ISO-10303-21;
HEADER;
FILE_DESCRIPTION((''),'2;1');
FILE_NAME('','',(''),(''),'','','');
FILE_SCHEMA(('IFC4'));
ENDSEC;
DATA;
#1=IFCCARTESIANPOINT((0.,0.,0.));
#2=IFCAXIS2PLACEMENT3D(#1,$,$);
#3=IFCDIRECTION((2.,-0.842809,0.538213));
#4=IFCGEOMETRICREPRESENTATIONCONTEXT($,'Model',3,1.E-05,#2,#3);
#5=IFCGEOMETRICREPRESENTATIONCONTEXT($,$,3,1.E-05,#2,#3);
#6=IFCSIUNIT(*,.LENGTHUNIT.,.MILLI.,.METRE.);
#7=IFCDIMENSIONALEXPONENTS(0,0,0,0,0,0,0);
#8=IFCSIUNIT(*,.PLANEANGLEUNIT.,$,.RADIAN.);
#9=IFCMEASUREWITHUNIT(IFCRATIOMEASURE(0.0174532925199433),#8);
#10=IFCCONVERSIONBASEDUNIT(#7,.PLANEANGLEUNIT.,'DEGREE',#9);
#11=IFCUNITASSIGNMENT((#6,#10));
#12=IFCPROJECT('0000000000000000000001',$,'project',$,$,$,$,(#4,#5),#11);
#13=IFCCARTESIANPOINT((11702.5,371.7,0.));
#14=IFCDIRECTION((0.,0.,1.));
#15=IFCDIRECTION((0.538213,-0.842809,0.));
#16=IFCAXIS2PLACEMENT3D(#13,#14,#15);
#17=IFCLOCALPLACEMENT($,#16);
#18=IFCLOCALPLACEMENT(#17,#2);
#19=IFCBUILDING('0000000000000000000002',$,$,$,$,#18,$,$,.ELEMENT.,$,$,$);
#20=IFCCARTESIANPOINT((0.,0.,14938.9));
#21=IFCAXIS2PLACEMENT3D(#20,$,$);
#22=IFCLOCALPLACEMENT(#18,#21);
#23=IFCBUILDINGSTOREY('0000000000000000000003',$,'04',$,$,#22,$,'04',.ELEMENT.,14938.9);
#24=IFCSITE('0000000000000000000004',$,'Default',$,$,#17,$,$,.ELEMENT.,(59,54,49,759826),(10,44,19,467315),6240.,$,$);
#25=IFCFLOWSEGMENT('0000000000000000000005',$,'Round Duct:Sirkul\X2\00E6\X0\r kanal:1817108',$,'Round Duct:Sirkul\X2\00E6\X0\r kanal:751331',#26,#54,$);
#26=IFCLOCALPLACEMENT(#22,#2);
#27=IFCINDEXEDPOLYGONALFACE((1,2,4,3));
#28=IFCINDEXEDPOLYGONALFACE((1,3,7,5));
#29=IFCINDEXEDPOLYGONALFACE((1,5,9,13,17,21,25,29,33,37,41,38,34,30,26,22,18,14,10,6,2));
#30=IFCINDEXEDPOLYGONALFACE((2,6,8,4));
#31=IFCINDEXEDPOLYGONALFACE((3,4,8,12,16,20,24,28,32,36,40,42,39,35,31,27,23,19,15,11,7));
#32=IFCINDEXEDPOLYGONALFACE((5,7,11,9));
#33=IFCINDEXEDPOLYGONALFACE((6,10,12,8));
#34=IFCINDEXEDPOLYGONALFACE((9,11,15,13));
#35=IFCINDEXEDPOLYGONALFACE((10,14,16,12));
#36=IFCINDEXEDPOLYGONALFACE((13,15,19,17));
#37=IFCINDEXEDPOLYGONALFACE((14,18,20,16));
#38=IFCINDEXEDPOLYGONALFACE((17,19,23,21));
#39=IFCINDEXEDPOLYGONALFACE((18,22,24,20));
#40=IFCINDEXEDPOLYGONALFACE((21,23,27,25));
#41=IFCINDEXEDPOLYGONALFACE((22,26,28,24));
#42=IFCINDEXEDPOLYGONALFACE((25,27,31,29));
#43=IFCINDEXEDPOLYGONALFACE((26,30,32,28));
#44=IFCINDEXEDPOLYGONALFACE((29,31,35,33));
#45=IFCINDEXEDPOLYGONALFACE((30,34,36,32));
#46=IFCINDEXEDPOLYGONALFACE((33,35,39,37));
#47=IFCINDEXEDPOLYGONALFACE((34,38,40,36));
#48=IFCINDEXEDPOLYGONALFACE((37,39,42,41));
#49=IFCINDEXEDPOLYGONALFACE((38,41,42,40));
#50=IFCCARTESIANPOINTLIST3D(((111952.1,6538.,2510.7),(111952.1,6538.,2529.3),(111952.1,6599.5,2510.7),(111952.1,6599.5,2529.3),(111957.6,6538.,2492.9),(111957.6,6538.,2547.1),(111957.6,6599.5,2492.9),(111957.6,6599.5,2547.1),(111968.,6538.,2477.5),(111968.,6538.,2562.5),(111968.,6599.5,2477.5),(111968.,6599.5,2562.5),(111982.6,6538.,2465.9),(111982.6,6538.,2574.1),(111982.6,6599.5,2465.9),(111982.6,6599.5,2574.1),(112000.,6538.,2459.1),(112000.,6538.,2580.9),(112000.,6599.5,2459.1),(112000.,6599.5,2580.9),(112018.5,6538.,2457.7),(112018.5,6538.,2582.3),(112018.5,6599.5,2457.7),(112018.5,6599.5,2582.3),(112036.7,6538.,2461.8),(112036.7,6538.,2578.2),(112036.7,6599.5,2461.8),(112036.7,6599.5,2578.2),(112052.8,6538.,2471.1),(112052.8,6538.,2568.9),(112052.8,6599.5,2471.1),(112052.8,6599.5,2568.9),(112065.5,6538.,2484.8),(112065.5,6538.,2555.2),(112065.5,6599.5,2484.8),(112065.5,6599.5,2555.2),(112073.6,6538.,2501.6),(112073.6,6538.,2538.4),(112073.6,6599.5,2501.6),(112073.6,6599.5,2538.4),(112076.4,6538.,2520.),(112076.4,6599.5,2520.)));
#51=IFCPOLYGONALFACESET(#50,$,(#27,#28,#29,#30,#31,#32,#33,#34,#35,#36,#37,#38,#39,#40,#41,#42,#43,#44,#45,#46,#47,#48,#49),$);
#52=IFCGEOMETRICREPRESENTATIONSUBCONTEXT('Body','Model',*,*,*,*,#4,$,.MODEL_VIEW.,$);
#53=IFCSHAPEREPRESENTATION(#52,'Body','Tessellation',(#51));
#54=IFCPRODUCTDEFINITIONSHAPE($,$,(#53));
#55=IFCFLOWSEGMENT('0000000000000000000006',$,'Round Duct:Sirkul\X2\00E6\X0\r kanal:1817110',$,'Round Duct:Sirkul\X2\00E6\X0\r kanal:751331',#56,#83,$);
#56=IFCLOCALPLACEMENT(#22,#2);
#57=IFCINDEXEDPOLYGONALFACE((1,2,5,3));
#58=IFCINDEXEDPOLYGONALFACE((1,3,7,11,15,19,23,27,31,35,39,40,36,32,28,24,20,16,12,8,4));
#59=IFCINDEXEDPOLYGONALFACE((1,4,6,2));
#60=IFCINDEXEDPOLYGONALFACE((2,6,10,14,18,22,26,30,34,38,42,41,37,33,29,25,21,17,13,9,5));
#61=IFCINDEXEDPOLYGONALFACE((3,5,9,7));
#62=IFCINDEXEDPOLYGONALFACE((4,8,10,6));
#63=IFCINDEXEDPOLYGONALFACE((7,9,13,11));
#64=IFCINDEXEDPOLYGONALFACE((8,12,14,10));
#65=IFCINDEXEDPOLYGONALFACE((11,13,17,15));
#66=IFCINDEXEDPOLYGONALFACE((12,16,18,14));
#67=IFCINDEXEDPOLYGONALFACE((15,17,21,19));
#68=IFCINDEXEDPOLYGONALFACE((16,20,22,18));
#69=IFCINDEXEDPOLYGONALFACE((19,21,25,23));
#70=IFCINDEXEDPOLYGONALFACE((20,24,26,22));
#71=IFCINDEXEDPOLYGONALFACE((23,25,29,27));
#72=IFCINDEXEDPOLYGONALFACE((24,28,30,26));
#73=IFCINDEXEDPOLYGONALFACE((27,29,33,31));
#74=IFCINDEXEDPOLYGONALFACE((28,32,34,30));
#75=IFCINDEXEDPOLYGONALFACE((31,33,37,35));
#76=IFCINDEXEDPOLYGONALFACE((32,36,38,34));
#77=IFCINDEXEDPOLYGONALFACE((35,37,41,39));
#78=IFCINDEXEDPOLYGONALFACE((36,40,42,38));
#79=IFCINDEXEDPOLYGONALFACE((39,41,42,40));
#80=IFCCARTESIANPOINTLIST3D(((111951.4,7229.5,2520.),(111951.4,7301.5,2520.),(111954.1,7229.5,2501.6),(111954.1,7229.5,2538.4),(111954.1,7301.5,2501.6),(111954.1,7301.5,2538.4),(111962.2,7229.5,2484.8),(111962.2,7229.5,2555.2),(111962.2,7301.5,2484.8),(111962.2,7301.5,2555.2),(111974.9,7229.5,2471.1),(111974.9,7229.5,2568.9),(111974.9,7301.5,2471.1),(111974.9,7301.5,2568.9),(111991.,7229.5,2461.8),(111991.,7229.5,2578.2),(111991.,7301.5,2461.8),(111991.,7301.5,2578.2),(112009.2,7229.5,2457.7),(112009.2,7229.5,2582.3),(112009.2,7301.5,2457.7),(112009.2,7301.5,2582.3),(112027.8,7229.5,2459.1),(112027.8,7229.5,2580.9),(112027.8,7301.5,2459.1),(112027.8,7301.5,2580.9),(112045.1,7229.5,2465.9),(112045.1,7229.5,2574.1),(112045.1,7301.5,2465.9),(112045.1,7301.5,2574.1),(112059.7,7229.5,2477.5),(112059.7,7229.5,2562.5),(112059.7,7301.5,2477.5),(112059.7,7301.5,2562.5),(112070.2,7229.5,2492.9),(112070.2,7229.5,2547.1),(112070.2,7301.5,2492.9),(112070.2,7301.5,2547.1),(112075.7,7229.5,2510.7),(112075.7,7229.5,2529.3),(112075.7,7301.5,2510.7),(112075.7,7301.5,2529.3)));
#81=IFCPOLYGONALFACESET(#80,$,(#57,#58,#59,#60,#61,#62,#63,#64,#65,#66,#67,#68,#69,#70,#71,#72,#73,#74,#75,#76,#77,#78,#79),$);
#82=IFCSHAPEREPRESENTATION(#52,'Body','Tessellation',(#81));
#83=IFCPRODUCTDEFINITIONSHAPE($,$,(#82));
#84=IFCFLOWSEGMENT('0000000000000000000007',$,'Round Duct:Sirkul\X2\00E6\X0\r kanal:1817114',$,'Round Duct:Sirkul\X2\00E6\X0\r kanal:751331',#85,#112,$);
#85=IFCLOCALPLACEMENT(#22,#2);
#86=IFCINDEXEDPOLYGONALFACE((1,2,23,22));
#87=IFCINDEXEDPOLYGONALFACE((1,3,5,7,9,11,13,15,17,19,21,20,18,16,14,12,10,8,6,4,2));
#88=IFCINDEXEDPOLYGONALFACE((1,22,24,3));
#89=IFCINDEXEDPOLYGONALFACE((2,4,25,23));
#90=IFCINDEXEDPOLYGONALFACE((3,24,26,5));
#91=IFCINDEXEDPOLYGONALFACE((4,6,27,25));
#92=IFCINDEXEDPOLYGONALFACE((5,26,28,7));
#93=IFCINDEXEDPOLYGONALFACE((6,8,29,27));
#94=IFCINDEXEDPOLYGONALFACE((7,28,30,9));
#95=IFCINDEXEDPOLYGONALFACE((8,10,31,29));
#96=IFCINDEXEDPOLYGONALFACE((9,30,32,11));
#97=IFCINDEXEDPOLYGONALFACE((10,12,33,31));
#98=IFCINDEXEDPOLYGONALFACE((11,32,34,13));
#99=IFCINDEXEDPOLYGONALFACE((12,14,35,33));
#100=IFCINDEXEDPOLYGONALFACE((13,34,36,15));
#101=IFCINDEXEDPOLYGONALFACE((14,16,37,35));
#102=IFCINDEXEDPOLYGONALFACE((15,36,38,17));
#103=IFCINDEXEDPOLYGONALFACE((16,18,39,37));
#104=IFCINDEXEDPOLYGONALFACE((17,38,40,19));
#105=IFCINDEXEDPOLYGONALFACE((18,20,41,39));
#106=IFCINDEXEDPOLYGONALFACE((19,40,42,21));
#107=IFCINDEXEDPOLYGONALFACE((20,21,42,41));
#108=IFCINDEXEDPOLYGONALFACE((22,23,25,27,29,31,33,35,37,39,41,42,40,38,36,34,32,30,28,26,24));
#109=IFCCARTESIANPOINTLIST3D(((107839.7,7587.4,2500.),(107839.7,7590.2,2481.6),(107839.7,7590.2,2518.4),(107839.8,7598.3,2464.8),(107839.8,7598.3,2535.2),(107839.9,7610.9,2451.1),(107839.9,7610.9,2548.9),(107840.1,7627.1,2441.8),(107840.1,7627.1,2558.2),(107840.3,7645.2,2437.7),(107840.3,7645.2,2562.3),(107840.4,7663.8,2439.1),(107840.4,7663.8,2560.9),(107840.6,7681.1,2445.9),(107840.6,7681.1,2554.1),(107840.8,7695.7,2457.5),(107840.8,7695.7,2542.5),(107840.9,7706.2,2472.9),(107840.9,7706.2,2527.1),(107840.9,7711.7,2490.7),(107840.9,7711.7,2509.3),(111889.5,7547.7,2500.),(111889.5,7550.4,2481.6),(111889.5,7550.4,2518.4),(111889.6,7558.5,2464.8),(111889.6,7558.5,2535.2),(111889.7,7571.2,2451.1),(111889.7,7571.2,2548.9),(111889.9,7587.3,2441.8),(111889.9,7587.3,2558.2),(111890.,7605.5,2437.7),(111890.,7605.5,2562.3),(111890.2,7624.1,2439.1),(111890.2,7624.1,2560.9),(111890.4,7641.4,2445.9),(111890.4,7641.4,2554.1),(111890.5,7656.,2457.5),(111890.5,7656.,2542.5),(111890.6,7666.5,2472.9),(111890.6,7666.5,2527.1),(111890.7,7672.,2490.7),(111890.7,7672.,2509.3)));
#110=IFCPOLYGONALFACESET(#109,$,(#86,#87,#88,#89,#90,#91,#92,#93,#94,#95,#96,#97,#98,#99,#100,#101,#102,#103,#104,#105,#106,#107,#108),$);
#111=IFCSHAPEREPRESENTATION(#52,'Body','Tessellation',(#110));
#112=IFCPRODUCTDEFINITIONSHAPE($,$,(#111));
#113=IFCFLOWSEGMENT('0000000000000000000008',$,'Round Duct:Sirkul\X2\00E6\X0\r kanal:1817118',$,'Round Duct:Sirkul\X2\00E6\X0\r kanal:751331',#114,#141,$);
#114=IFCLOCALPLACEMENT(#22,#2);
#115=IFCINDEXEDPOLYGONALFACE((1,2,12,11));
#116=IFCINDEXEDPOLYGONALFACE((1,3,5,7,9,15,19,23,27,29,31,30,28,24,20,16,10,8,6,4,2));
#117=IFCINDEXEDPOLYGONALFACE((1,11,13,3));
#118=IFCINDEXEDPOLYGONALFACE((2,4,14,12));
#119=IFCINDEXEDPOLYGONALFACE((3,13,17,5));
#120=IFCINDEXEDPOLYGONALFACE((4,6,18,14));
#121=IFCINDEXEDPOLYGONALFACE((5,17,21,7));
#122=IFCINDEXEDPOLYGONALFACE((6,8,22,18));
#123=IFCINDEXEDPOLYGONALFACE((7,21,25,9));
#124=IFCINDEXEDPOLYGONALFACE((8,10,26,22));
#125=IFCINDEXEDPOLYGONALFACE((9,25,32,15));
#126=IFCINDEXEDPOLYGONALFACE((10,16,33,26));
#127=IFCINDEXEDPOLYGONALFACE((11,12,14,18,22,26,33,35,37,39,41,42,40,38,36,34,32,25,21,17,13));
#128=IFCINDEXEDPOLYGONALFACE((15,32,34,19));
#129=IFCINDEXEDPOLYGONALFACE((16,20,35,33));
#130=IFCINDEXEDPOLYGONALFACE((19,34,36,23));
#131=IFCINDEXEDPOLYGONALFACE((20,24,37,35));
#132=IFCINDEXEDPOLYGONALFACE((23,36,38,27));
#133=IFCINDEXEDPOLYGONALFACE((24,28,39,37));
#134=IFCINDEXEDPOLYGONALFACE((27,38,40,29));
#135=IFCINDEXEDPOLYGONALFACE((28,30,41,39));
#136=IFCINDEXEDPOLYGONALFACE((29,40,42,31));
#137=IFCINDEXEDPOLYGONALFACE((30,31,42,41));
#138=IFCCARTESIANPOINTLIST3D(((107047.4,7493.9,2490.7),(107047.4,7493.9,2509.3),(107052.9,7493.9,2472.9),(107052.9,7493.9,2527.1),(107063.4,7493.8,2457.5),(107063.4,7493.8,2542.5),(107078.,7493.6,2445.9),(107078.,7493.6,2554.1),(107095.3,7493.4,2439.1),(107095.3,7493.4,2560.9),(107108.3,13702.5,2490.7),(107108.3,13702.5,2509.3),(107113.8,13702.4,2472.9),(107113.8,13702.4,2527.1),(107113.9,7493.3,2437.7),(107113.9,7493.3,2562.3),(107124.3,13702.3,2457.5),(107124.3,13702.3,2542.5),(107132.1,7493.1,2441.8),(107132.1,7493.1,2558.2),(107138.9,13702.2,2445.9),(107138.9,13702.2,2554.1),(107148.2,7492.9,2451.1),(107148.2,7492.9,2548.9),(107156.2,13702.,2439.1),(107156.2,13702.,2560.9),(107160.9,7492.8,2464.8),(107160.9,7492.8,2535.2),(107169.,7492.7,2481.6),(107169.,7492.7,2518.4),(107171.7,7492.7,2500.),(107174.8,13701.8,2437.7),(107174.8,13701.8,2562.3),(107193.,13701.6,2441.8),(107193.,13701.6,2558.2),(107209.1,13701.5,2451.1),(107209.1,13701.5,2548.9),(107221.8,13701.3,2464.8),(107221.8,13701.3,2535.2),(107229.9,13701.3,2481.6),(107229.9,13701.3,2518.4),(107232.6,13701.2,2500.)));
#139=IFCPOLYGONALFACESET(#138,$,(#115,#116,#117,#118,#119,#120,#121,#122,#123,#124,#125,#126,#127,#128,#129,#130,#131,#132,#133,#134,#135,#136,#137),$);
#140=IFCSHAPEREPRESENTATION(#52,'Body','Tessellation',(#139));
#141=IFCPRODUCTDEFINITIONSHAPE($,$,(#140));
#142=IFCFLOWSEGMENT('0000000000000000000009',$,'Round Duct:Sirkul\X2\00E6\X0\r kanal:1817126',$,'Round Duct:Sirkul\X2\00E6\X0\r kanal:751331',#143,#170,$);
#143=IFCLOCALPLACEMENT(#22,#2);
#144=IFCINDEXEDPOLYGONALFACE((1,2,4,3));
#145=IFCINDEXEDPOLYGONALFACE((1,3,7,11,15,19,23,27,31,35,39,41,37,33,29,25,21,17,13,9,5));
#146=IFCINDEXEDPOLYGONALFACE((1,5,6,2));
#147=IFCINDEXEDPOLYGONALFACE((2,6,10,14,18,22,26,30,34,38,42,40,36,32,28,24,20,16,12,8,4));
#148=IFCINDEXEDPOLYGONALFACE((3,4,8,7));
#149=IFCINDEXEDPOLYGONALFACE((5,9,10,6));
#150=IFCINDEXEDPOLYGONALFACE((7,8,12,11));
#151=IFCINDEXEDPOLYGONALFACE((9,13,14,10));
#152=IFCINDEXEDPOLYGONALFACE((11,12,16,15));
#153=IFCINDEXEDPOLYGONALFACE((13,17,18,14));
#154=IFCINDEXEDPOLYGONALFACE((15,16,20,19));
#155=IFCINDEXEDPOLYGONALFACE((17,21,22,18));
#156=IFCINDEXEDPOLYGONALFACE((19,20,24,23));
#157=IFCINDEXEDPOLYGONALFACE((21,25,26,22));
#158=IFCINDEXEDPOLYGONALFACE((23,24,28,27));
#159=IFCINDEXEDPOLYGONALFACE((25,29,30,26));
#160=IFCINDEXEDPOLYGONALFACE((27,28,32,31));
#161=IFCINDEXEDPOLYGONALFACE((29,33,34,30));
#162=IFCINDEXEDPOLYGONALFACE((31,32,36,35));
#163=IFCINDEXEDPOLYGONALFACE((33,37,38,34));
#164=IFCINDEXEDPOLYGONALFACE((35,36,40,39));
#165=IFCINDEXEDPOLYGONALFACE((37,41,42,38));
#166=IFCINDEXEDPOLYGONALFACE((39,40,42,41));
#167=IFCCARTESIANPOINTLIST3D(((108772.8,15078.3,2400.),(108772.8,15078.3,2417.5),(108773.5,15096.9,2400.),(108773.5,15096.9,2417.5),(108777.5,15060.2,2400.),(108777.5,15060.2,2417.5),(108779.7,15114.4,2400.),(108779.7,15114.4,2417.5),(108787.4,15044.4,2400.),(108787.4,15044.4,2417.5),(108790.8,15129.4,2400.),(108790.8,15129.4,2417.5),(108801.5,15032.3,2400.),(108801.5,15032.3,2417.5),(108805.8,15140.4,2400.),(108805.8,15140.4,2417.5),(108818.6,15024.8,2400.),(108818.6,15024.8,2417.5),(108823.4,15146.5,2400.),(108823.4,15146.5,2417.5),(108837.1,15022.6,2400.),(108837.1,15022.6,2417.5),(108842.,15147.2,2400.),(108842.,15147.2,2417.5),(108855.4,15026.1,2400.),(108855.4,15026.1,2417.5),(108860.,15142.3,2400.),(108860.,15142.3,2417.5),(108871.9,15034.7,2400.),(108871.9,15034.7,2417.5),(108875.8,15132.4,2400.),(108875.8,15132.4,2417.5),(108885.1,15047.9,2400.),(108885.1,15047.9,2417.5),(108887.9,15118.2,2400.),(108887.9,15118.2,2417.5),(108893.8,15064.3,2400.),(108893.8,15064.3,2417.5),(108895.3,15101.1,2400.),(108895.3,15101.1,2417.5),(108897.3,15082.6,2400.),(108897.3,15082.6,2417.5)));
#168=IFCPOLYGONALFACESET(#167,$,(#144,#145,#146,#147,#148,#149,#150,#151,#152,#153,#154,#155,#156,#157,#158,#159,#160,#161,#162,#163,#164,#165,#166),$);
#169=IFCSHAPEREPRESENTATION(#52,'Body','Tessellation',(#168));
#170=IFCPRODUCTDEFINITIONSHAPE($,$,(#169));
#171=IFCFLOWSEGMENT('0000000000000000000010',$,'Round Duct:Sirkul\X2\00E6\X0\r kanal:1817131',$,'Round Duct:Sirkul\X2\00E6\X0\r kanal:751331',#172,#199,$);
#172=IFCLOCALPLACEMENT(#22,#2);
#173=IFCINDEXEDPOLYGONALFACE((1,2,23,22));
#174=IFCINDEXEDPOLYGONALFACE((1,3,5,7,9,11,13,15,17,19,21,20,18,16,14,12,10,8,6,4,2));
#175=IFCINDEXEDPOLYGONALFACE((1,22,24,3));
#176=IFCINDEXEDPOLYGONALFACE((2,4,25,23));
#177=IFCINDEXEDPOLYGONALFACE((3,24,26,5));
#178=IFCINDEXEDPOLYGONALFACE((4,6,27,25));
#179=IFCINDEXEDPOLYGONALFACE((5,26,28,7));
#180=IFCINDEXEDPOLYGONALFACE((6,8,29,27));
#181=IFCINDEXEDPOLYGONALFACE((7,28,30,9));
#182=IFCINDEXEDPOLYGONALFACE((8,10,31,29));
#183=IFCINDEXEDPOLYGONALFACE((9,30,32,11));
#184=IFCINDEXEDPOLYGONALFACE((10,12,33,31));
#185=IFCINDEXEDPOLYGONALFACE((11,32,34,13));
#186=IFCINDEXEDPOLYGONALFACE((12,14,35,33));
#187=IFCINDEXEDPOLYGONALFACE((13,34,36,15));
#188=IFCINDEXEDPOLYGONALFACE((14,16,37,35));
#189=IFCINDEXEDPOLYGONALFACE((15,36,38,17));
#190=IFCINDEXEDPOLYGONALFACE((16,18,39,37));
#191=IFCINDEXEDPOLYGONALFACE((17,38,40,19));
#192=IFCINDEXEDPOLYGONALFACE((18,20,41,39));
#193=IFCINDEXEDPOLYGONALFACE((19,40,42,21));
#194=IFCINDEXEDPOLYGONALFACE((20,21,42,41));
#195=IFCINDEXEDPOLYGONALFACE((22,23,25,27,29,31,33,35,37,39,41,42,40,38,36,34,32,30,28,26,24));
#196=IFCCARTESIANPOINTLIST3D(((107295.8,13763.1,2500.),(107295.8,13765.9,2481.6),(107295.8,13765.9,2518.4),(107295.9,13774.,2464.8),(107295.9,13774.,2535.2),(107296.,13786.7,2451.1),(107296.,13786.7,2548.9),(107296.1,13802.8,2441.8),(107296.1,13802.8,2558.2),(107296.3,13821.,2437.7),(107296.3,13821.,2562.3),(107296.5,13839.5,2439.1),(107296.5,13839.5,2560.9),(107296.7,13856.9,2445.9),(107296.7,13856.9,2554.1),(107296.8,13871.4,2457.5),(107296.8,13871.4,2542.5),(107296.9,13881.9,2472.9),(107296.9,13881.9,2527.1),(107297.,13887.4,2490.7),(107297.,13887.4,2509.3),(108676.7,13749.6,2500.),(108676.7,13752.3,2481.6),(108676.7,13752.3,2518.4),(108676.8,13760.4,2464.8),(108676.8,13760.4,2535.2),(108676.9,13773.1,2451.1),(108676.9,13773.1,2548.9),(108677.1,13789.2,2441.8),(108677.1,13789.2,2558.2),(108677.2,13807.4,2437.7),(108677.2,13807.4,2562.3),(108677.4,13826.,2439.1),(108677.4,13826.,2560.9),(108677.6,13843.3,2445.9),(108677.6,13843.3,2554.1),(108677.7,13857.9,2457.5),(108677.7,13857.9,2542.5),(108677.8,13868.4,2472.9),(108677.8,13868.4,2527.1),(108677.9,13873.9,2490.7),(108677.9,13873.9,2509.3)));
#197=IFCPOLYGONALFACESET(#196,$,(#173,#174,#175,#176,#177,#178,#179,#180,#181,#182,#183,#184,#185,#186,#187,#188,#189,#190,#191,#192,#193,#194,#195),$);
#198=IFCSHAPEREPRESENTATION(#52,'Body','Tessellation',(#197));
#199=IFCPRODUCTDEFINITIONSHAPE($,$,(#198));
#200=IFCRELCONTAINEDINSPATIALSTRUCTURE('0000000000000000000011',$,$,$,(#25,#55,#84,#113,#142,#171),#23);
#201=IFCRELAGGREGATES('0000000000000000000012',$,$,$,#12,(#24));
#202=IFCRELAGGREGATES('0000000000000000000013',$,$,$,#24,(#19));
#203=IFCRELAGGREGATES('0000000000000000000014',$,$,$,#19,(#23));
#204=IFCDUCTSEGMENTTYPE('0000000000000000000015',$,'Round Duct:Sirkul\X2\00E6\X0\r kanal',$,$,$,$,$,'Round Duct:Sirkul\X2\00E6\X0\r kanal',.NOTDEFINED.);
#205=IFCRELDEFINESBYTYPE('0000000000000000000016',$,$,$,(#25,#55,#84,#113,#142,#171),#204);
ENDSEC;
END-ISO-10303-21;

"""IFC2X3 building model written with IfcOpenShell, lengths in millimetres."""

from ifc_helpers import new_model, entity, si_unit, converted_unit, direction, frame, frame_2d, origin, origin_2d_with_axis, place, context, subcontext, project, spatial, circle, extrude, type_object, element, save


model = new_model("IFC2X3")

# Units and contexts
model_context = context("Model", 3, precision=1e-05, world=origin(), true_north=direction((2.0, -0.842809, 0.538213)))
context_of_model = context(None, 3, precision=1e-05, world=origin(), true_north=direction((2.0, -0.842809, 0.538213)))
body_context = subcontext(model_context, "Body", "Model", "MODEL_VIEW")
ifc_project = project(units=[si_unit("LENGTHUNIT", "METRE", prefix="MILLI"), converted_unit("PLANEANGLEUNIT", "DEGREE", entity("IfcRatioMeasure", 0.0174532925199433), si_unit("PLANEANGLEUNIT", "RADIAN"), dimensions=[0, 0, 0, 0, 0, 0, 0])], contexts=[model_context, context_of_model])

# Site, building, storey
site_placement = place(None, frame((11702.5, 371.7, 0.0), z_axis=(0.0, 0.0, 1.0), x_axis=(0.538213, -0.842809, 0.0)))
site = spatial("IfcSite", under=ifc_project, at=site_placement, Name="Default", CompositionType="ELEMENT", RefLatitude=(59, 54, 49, 759826), RefLongitude=(10, 44, 19, 467315), RefElevation=6240.0)
building_placement = place(site_placement, origin())
building = spatial("IfcBuilding", under=site, at=building_placement, CompositionType="ELEMENT")
storey_placement = place(building_placement, frame((0.0, 0.0, 14938.9)))
storey = spatial("IfcBuildingStorey", under=building, at=storey_placement, Name="04", LongName="04", CompositionType="ELEMENT", Elevation=14938.9)

# Flow segments
duct_segment_type = type_object("IfcDuctSegmentType", Name="Round Duct:Sirkulær kanal", ElementType="Round Duct:Sirkulær kanal", PredefinedType="NOTDEFINED")
flow_segment_1_placement = place(storey_placement, origin())
element("IfcFlowSegment", 1, at=flow_segment_1_placement, inside=storey, type_object=duct_segment_type, Name="Round Duct:Sirkulær kanal:1817108", ObjectType="Round Duct:Sirkulær kanal:751331", context=body_context, shape_type="SweptSolid", body=[
    extrude(circle(Radius=62.5, at=frame_2d((0.0, 0.0), x_axis=(1.0, 0.0))), frame((112013.9, 6538.0, 2520.0), z_axis=(0.000003, 1.0, 0.0), x_axis=(1.0, -0.000003, 0.0)), (0.0, 0.0, 1.0), 61.5),
])
flow_segment_2_placement = place(storey_placement, origin())
element("IfcFlowSegment", 2, at=flow_segment_2_placement, inside=storey, type_object=duct_segment_type, Name="Round Duct:Sirkulær kanal:1817110", ObjectType="Round Duct:Sirkulær kanal:751331", context=body_context, shape_type="SweptSolid", body=[
    extrude(circle(Radius=62.5, at=origin_2d_with_axis()), frame((112013.9, 7229.5, 2520.0), z_axis=(0.000003, 1.0, 0.0), x_axis=(-1.0, 0.000003, 0.0)), (0.0, 0.0, 1.0), 72.0),
])
flow_segment_3_placement = place(storey_placement, origin())
element("IfcFlowSegment", 3, at=flow_segment_3_placement, inside=storey, type_object=duct_segment_type, Name="Round Duct:Sirkulær kanal:1817114", ObjectType="Round Duct:Sirkulær kanal:751331", context=body_context, shape_type="SweptSolid", body=[
    extrude(circle(Radius=62.5, at=origin_2d_with_axis()), frame((107840.3, 7649.9, 2500.0), z_axis=(0.999952, -0.00981, 0.0), x_axis=(-0.00981, -0.999952, 0.0)), (0.0, 0.0, 1.0), 4050.0),
])
flow_segment_4_placement = place(storey_placement, origin())
element("IfcFlowSegment", 4, at=flow_segment_4_placement, inside=storey, type_object=duct_segment_type, Name="Round Duct:Sirkulær kanal:1817118", ObjectType="Round Duct:Sirkulær kanal:751331", context=body_context, shape_type="SweptSolid", body=[
    extrude(circle(Radius=62.5, at=origin_2d_with_axis()), frame((107109.2, 7493.3, 2500.0), z_axis=(0.00981, 0.999952, 0.0), x_axis=(0.999952, -0.00981, 0.0)), (0.0, 0.0, 1.0), 6208.9),
])
flow_segment_5_placement = place(storey_placement, origin())
element("IfcFlowSegment", 5, at=flow_segment_5_placement, inside=storey, type_object=duct_segment_type, Name="Round Duct:Sirkulær kanal:1817126", ObjectType="Round Duct:Sirkulær kanal:751331", context=body_context, shape_type="SweptSolid", body=[
    extrude(circle(Radius=62.5, at=frame_2d((0.0, 0.0), x_axis=(1.0, 0.0))), frame((108834.9, 15085.1, 2400.0), z_axis=(0.0, 0.0, 1.0), x_axis=(0.803212, -0.595694, 0.0)), (0.0, 0.0, 1.0), 17.5),
])
flow_segment_6_placement = place(storey_placement, origin())
element("IfcFlowSegment", 6, at=flow_segment_6_placement, inside=storey, type_object=duct_segment_type, Name="Round Duct:Sirkulær kanal:1817131", ObjectType="Round Duct:Sirkulær kanal:751331", context=body_context, shape_type="SweptSolid", body=[
    extrude(circle(Radius=62.5, at=frame_2d((0.0, 0.0), x_axis=(1.0, 0.0))), frame((107296.4, 13825.6, 2500.0), z_axis=(0.999952, -0.009828, 0.0), x_axis=(-0.009828, -0.999952, 0.0)), (0.0, 0.0, 1.0), 1381.0),
])

save(model, "model.ifc")
